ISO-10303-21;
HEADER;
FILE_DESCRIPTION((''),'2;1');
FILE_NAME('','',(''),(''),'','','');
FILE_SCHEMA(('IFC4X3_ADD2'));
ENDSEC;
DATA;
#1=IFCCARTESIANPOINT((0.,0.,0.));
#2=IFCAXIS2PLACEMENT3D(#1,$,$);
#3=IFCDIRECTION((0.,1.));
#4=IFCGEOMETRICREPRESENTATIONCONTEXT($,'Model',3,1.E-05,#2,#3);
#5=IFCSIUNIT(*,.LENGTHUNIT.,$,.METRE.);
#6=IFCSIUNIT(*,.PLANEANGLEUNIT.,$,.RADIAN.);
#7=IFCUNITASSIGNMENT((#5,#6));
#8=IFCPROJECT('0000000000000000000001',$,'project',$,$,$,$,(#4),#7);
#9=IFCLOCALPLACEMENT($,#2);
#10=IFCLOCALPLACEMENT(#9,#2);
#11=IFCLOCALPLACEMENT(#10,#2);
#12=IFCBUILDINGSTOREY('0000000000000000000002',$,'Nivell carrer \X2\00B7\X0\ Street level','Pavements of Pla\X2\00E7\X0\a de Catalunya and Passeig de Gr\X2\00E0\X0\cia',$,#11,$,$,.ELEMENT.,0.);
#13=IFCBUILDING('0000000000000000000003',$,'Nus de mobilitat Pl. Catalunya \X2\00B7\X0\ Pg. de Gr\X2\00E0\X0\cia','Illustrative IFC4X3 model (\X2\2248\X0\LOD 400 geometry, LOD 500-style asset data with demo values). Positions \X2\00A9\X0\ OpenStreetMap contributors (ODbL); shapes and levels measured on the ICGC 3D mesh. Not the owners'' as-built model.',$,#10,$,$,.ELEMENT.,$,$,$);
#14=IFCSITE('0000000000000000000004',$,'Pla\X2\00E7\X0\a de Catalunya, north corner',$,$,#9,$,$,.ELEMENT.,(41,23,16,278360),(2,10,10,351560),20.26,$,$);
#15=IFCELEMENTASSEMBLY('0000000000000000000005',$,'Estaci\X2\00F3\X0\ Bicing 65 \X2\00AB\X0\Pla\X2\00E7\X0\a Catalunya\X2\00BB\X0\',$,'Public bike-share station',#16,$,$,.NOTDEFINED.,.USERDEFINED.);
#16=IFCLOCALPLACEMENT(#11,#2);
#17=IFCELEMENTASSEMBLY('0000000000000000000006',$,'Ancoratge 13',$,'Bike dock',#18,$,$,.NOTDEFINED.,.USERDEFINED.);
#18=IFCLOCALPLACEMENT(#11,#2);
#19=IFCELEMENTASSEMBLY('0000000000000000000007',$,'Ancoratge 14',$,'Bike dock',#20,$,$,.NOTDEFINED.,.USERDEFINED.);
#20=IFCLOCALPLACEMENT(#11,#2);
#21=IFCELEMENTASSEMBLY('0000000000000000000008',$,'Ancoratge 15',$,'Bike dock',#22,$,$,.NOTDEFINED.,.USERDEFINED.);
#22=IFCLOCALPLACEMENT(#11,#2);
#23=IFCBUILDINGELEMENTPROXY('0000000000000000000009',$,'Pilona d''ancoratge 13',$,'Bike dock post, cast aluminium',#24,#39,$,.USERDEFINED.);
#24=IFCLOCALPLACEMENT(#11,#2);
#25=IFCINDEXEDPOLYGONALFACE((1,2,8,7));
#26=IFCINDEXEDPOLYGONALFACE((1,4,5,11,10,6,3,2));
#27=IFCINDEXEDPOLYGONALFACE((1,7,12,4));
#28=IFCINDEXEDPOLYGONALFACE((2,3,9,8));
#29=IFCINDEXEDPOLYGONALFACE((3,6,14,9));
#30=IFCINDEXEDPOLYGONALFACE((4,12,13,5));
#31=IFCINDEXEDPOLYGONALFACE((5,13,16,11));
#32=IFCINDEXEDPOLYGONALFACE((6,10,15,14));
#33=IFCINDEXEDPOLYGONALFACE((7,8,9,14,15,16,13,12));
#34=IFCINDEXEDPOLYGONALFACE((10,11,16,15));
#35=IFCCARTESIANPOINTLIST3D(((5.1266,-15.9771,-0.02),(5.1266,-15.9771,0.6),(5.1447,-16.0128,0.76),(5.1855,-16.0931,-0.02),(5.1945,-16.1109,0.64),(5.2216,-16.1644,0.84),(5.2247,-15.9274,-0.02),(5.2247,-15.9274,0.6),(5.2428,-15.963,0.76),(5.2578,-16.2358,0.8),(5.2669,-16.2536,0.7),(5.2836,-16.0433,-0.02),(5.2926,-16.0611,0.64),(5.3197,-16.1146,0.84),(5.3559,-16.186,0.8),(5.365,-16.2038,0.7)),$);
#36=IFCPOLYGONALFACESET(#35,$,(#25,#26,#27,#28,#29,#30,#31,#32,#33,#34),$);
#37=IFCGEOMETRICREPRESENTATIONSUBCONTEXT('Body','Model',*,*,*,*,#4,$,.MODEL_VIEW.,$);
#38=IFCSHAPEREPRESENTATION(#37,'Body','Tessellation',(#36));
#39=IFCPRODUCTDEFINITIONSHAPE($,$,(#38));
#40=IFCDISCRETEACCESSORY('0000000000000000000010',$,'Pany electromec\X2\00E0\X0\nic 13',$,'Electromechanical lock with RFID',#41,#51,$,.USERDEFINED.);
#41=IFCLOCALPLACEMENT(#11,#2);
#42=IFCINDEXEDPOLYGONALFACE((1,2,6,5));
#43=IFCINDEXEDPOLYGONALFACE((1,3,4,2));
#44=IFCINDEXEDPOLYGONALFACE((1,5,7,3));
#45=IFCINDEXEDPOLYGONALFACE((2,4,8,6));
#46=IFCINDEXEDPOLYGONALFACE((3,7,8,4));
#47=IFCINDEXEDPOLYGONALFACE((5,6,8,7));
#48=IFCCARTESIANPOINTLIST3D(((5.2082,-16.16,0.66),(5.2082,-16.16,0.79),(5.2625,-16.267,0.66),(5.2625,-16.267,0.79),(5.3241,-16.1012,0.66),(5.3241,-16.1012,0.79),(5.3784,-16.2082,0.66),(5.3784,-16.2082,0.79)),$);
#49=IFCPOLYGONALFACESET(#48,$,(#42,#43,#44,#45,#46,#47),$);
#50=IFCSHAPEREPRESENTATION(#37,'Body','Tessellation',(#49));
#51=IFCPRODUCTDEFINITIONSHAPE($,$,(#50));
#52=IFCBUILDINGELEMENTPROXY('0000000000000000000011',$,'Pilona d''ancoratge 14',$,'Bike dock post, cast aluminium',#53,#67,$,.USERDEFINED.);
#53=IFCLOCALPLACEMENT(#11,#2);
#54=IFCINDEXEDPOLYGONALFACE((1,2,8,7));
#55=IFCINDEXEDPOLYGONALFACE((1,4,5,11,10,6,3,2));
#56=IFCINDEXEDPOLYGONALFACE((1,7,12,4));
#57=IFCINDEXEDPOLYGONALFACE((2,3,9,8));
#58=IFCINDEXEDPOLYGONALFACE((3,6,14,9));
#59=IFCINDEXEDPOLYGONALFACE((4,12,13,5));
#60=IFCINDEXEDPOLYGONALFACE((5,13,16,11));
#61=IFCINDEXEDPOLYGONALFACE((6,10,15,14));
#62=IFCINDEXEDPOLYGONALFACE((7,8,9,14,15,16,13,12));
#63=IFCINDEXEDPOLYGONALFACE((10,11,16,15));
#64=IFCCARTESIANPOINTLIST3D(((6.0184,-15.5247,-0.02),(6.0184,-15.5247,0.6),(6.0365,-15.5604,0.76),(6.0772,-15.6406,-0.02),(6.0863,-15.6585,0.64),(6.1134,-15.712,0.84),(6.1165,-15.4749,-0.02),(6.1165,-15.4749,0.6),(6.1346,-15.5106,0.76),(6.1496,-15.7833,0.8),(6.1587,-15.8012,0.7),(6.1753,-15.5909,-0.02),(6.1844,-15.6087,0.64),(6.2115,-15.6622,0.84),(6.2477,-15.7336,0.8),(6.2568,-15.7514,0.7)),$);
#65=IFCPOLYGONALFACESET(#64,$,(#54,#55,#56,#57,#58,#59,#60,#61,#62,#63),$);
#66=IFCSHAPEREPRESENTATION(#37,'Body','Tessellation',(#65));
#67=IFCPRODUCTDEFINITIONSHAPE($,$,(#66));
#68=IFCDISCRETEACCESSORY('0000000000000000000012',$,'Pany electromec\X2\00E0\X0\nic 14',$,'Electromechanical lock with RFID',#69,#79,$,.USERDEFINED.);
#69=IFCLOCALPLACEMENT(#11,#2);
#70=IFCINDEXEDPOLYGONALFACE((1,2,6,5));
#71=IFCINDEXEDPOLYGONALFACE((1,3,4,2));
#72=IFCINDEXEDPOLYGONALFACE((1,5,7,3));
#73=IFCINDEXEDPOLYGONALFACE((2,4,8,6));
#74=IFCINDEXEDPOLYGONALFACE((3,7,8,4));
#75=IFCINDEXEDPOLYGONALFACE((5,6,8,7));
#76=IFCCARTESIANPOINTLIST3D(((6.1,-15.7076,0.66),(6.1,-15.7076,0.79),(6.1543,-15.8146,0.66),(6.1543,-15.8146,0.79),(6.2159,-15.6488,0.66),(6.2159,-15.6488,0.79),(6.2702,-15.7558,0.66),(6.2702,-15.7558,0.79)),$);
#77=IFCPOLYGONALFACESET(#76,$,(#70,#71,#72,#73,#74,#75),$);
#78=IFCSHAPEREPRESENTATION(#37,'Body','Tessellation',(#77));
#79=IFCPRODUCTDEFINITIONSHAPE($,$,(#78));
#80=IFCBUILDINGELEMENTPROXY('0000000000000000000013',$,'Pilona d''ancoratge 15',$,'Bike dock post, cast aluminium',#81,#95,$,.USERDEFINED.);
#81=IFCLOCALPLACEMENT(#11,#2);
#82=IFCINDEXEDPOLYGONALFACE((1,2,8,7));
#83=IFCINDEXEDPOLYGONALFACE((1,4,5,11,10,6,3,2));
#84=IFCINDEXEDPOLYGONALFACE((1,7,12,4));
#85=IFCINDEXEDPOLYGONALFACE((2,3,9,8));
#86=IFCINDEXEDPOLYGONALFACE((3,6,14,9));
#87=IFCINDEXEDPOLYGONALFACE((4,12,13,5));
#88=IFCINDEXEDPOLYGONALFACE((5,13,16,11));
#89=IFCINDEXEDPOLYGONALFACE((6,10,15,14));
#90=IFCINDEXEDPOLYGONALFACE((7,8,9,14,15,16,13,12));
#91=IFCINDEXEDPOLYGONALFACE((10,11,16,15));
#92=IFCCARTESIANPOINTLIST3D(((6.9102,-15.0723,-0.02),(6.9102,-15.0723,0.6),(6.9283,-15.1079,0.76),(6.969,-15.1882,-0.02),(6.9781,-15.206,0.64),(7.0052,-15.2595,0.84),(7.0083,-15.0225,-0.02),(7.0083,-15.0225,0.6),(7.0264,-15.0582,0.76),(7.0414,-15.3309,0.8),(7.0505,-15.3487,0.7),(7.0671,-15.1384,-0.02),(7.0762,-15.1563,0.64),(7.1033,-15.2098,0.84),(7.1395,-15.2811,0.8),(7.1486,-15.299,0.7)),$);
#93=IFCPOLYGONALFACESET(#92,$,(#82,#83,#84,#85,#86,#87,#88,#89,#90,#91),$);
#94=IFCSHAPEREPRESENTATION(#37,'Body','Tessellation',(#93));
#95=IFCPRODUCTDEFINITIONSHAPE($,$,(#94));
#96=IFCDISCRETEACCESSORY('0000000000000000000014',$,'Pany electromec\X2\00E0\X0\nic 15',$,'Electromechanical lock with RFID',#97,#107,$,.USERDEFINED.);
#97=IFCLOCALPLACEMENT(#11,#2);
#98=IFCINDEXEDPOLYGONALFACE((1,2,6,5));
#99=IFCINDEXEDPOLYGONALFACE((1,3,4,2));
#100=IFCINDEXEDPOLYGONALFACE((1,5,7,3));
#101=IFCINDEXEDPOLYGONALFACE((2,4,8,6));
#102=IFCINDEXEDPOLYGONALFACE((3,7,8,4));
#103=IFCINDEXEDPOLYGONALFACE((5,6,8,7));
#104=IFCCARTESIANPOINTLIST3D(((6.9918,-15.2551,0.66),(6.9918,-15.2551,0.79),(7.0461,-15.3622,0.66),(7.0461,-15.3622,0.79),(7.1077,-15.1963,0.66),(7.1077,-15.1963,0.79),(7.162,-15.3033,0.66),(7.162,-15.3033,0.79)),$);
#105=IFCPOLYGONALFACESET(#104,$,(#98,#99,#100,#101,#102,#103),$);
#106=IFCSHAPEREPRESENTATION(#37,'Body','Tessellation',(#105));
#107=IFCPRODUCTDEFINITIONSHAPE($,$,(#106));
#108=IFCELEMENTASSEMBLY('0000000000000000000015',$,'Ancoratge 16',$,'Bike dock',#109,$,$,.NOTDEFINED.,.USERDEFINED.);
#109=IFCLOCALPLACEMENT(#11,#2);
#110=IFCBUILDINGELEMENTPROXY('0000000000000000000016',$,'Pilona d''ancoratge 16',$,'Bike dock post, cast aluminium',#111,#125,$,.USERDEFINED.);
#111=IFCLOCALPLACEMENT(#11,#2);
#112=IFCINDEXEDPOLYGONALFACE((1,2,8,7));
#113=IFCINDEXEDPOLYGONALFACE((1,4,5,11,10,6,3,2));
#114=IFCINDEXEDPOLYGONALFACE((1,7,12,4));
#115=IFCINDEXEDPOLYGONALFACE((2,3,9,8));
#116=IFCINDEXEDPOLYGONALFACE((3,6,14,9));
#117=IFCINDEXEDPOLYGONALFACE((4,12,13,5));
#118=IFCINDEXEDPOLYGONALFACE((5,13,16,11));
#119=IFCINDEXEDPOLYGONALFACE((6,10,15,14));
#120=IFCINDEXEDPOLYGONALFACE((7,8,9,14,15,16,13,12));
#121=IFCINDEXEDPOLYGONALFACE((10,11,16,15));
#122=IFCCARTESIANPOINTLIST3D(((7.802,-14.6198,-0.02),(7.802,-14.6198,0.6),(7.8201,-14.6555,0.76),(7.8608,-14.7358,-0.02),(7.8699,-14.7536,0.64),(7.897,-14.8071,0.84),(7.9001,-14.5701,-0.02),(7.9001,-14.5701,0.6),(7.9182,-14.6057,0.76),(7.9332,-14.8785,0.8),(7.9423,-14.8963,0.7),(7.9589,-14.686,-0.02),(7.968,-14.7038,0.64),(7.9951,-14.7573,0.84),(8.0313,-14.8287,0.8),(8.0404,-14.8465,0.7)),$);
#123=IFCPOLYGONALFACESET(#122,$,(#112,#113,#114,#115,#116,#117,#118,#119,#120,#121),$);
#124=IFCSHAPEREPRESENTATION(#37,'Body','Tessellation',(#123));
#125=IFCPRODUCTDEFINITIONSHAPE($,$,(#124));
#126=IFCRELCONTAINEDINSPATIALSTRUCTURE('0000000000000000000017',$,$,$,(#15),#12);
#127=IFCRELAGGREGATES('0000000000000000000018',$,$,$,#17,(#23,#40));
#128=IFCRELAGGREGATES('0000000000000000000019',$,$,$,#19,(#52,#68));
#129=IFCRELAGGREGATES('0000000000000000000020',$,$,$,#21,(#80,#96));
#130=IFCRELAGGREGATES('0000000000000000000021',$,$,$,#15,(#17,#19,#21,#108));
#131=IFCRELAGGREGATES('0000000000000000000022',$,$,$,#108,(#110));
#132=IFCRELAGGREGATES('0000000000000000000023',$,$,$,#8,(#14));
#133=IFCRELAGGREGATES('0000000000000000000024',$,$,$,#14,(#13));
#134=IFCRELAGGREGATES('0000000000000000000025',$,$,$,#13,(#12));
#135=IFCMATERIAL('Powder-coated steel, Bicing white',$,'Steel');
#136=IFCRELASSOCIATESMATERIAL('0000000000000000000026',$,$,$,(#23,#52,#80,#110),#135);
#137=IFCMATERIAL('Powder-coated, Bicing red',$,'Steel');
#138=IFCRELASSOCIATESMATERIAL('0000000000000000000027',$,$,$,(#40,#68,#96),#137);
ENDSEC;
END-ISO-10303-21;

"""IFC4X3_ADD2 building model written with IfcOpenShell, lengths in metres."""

from ifc_helpers import new_model, si_unit, direction, frame, frame_2d, origin, place, context, subcontext, project, spatial, polyline, rectangle, outline, extrude, material, element, aggregate, save


model = new_model("IFC4X3_ADD2")

# Units and contexts
model_context = context("Model", 3, precision=1e-05, world=origin(), true_north=direction((0.0, 1.0)))
body_context = subcontext(model_context, "Body", "Model", "MODEL_VIEW")
ifc_project = project(units=[si_unit("LENGTHUNIT", "METRE"), si_unit("PLANEANGLEUNIT", "RADIAN")], contexts=[model_context])

# Site, building, storey
site_placement = place(None, origin())
site = spatial("IfcSite", under=ifc_project, at=site_placement, Name="Plaça de Catalunya, north corner", CompositionType="ELEMENT", RefLatitude=(41, 23, 16, 278360), RefLongitude=(2, 10, 10, 351560), RefElevation=20.26)
building_placement = place(site_placement, origin())
building = spatial("IfcBuilding", under=site, at=building_placement, Name="Nus de mobilitat Pl. Catalunya · Pg. de Gràcia", Description="Illustrative IFC4X3 model (≈LOD 400 geometry, LOD 500-style asset data with demo values). Positions © OpenStreetMap contributors (ODbL); shapes and levels measured on the ICGC 3D mesh. Not the owners' as-built model.", CompositionType="ELEMENT")
storey_placement = place(building_placement, origin())
storey = spatial("IfcBuildingStorey", under=building, at=storey_placement, Name="Nivell carrer · Street level", Description="Pavements of Plaça de Catalunya and Passeig de Gràcia", CompositionType="ELEMENT", Elevation=0.0)

# Element assemblies, building element proxies, discrete accessories
assembly_1_placement = place(building_placement, origin())
assembly_1 = element("IfcElementAssembly", 1, at=assembly_1_placement, inside=storey, Name="Estació Bicing 65 «Plaça Catalunya»", ObjectType="Public bike-share station", AssemblyPlace="NOTDEFINED", PredefinedType="USERDEFINED")
ifc_material_1 = material(Name="Powder-coated, Bicing red", Category="Steel")
assembly_2_placement = place(building_placement, origin())
assembly_2 = element("IfcElementAssembly", 2, at=assembly_2_placement, Name="Ancoratge 13", ObjectType="Bike dock", AssemblyPlace="NOTDEFINED", PredefinedType="USERDEFINED")
assembly_3_placement = place(building_placement, origin())
assembly_3 = element("IfcElementAssembly", 3, at=assembly_3_placement, Name="Ancoratge 14", ObjectType="Bike dock", AssemblyPlace="NOTDEFINED", PredefinedType="USERDEFINED")
assembly_4_placement = place(building_placement, origin())
assembly_4 = element("IfcElementAssembly", 4, at=assembly_4_placement, Name="Ancoratge 15", ObjectType="Bike dock", AssemblyPlace="NOTDEFINED", PredefinedType="USERDEFINED")
ifc_material_2 = material(Name="Powder-coated steel, Bicing white", Category="Steel")
proxy_1_placement = place(building_placement, origin())
proxy_1 = element("IfcBuildingElementProxy", 5, at=proxy_1_placement, material=ifc_material_2, Name="Pilona d'ancoratge 13", ObjectType="Bike dock post, cast aluminium", PredefinedType="USERDEFINED", context=body_context, shape_type="SweptSolid", body=[
    extrude(outline(polyline([(0.07, 0.06), (0.07, 0.68), (0.03, 0.84), (-0.14, 0.92), (-0.22, 0.88), (-0.24, 0.78), (-0.08, 0.72), (-0.06, 0.06), (0.07, 0.06)])), frame((5.1583, -16.0396, -0.08), z_axis=(0.891798, 0.452435, 0.0), x_axis=(-0.452435, 0.891798, 0.0)), (0.0, 0.0, 1.0), 0.11),
])
discrete_accessory_1_placement = place(building_placement, origin())
discrete_accessory_1 = element("IfcDiscreteAccessory", 6, at=discrete_accessory_1_placement, material=ifc_material_1, Name="Pany electromecànic 13", ObjectType="Electromechanical lock with RFID", PredefinedType="USERDEFINED", context=body_context, shape_type="SweptSolid", body=[
    extrude(rectangle(XDim=0.13, YDim=0.12, at=frame_2d((0.0, 0.0), x_axis=(0.891798, 0.452435))), frame((5.2933, -16.1841, 0.66)), (0.0, 0.0, 1.0), 0.13),
])
aggregate(assembly_2, [proxy_1, discrete_accessory_1])
proxy_2_placement = place(building_placement, origin())
proxy_2 = element("IfcBuildingElementProxy", 7, at=proxy_2_placement, material=ifc_material_2, Name="Pilona d'ancoratge 14", ObjectType="Bike dock post, cast aluminium", PredefinedType="USERDEFINED", context=body_context, shape_type="SweptSolid", body=[
    extrude(outline(polyline([(0.07, 0.06), (0.07, 0.68), (0.03, 0.84), (-0.14, 0.92), (-0.22, 0.88), (-0.24, 0.78), (-0.08, 0.72), (-0.06, 0.06), (0.07, 0.06)])), frame((6.0501, -15.5871, -0.08), z_axis=(0.891798, 0.452435, 0.0), x_axis=(-0.452435, 0.891798, 0.0)), (0.0, 0.0, 1.0), 0.11),
])
discrete_accessory_2_placement = place(building_placement, origin())
discrete_accessory_2 = element("IfcDiscreteAccessory", 8, at=discrete_accessory_2_placement, material=ifc_material_1, Name="Pany electromecànic 14", ObjectType="Electromechanical lock with RFID", PredefinedType="USERDEFINED", context=body_context, shape_type="SweptSolid", body=[
    extrude(rectangle(XDim=0.13, YDim=0.12, at=frame_2d((0.0, 0.0), x_axis=(0.891798, 0.452435))), frame((6.1851, -15.7317, 0.66)), (0.0, 0.0, 1.0), 0.13),
])
aggregate(assembly_3, [proxy_2, discrete_accessory_2])
proxy_3_placement = place(building_placement, origin())
proxy_3 = element("IfcBuildingElementProxy", 9, at=proxy_3_placement, material=ifc_material_2, Name="Pilona d'ancoratge 15", ObjectType="Bike dock post, cast aluminium", PredefinedType="USERDEFINED", context=body_context, shape_type="SweptSolid", body=[
    extrude(outline(polyline([(0.07, 0.06), (0.07, 0.68), (0.03, 0.84), (-0.14, 0.92), (-0.22, 0.88), (-0.24, 0.78), (-0.08, 0.72), (-0.06, 0.06), (0.07, 0.06)])), frame((6.9419, -15.1347, -0.08), z_axis=(0.891798, 0.452435, 0.0), x_axis=(-0.452435, 0.891798, 0.0)), (0.0, 0.0, 1.0), 0.11),
])
discrete_accessory_3_placement = place(building_placement, origin())
discrete_accessory_3 = element("IfcDiscreteAccessory", 10, at=discrete_accessory_3_placement, material=ifc_material_1, Name="Pany electromecànic 15", ObjectType="Electromechanical lock with RFID", PredefinedType="USERDEFINED", context=body_context, shape_type="SweptSolid", body=[
    extrude(rectangle(XDim=0.13, YDim=0.12, at=frame_2d((0.0, 0.0), x_axis=(0.891798, 0.452435))), frame((7.0769, -15.2792, 0.66)), (0.0, 0.0, 1.0), 0.13),
])
aggregate(assembly_4, [proxy_3, discrete_accessory_3])
assembly_5_placement = place(building_placement, origin())
assembly_5 = element("IfcElementAssembly", 11, at=assembly_5_placement, Name="Ancoratge 16", ObjectType="Bike dock", AssemblyPlace="NOTDEFINED", PredefinedType="USERDEFINED")
aggregate(assembly_1, [assembly_2, assembly_3, assembly_4, assembly_5])
proxy_4_placement = place(building_placement, origin())
proxy_4 = element("IfcBuildingElementProxy", 12, at=proxy_4_placement, material=ifc_material_2, Name="Pilona d'ancoratge 16", ObjectType="Bike dock post, cast aluminium", PredefinedType="USERDEFINED", context=body_context, shape_type="SweptSolid", body=[
    extrude(outline(polyline([(0.07, 0.06), (0.07, 0.68), (0.03, 0.84), (-0.14, 0.92), (-0.22, 0.88), (-0.24, 0.78), (-0.08, 0.72), (-0.06, 0.06), (0.07, 0.06)])), frame((7.8337, -14.6823, -0.08), z_axis=(0.891798, 0.452435, 0.0), x_axis=(-0.452435, 0.891798, 0.0)), (0.0, 0.0, 1.0), 0.11),
])
aggregate(assembly_5, [proxy_4])

save(model, "model.ifc")
